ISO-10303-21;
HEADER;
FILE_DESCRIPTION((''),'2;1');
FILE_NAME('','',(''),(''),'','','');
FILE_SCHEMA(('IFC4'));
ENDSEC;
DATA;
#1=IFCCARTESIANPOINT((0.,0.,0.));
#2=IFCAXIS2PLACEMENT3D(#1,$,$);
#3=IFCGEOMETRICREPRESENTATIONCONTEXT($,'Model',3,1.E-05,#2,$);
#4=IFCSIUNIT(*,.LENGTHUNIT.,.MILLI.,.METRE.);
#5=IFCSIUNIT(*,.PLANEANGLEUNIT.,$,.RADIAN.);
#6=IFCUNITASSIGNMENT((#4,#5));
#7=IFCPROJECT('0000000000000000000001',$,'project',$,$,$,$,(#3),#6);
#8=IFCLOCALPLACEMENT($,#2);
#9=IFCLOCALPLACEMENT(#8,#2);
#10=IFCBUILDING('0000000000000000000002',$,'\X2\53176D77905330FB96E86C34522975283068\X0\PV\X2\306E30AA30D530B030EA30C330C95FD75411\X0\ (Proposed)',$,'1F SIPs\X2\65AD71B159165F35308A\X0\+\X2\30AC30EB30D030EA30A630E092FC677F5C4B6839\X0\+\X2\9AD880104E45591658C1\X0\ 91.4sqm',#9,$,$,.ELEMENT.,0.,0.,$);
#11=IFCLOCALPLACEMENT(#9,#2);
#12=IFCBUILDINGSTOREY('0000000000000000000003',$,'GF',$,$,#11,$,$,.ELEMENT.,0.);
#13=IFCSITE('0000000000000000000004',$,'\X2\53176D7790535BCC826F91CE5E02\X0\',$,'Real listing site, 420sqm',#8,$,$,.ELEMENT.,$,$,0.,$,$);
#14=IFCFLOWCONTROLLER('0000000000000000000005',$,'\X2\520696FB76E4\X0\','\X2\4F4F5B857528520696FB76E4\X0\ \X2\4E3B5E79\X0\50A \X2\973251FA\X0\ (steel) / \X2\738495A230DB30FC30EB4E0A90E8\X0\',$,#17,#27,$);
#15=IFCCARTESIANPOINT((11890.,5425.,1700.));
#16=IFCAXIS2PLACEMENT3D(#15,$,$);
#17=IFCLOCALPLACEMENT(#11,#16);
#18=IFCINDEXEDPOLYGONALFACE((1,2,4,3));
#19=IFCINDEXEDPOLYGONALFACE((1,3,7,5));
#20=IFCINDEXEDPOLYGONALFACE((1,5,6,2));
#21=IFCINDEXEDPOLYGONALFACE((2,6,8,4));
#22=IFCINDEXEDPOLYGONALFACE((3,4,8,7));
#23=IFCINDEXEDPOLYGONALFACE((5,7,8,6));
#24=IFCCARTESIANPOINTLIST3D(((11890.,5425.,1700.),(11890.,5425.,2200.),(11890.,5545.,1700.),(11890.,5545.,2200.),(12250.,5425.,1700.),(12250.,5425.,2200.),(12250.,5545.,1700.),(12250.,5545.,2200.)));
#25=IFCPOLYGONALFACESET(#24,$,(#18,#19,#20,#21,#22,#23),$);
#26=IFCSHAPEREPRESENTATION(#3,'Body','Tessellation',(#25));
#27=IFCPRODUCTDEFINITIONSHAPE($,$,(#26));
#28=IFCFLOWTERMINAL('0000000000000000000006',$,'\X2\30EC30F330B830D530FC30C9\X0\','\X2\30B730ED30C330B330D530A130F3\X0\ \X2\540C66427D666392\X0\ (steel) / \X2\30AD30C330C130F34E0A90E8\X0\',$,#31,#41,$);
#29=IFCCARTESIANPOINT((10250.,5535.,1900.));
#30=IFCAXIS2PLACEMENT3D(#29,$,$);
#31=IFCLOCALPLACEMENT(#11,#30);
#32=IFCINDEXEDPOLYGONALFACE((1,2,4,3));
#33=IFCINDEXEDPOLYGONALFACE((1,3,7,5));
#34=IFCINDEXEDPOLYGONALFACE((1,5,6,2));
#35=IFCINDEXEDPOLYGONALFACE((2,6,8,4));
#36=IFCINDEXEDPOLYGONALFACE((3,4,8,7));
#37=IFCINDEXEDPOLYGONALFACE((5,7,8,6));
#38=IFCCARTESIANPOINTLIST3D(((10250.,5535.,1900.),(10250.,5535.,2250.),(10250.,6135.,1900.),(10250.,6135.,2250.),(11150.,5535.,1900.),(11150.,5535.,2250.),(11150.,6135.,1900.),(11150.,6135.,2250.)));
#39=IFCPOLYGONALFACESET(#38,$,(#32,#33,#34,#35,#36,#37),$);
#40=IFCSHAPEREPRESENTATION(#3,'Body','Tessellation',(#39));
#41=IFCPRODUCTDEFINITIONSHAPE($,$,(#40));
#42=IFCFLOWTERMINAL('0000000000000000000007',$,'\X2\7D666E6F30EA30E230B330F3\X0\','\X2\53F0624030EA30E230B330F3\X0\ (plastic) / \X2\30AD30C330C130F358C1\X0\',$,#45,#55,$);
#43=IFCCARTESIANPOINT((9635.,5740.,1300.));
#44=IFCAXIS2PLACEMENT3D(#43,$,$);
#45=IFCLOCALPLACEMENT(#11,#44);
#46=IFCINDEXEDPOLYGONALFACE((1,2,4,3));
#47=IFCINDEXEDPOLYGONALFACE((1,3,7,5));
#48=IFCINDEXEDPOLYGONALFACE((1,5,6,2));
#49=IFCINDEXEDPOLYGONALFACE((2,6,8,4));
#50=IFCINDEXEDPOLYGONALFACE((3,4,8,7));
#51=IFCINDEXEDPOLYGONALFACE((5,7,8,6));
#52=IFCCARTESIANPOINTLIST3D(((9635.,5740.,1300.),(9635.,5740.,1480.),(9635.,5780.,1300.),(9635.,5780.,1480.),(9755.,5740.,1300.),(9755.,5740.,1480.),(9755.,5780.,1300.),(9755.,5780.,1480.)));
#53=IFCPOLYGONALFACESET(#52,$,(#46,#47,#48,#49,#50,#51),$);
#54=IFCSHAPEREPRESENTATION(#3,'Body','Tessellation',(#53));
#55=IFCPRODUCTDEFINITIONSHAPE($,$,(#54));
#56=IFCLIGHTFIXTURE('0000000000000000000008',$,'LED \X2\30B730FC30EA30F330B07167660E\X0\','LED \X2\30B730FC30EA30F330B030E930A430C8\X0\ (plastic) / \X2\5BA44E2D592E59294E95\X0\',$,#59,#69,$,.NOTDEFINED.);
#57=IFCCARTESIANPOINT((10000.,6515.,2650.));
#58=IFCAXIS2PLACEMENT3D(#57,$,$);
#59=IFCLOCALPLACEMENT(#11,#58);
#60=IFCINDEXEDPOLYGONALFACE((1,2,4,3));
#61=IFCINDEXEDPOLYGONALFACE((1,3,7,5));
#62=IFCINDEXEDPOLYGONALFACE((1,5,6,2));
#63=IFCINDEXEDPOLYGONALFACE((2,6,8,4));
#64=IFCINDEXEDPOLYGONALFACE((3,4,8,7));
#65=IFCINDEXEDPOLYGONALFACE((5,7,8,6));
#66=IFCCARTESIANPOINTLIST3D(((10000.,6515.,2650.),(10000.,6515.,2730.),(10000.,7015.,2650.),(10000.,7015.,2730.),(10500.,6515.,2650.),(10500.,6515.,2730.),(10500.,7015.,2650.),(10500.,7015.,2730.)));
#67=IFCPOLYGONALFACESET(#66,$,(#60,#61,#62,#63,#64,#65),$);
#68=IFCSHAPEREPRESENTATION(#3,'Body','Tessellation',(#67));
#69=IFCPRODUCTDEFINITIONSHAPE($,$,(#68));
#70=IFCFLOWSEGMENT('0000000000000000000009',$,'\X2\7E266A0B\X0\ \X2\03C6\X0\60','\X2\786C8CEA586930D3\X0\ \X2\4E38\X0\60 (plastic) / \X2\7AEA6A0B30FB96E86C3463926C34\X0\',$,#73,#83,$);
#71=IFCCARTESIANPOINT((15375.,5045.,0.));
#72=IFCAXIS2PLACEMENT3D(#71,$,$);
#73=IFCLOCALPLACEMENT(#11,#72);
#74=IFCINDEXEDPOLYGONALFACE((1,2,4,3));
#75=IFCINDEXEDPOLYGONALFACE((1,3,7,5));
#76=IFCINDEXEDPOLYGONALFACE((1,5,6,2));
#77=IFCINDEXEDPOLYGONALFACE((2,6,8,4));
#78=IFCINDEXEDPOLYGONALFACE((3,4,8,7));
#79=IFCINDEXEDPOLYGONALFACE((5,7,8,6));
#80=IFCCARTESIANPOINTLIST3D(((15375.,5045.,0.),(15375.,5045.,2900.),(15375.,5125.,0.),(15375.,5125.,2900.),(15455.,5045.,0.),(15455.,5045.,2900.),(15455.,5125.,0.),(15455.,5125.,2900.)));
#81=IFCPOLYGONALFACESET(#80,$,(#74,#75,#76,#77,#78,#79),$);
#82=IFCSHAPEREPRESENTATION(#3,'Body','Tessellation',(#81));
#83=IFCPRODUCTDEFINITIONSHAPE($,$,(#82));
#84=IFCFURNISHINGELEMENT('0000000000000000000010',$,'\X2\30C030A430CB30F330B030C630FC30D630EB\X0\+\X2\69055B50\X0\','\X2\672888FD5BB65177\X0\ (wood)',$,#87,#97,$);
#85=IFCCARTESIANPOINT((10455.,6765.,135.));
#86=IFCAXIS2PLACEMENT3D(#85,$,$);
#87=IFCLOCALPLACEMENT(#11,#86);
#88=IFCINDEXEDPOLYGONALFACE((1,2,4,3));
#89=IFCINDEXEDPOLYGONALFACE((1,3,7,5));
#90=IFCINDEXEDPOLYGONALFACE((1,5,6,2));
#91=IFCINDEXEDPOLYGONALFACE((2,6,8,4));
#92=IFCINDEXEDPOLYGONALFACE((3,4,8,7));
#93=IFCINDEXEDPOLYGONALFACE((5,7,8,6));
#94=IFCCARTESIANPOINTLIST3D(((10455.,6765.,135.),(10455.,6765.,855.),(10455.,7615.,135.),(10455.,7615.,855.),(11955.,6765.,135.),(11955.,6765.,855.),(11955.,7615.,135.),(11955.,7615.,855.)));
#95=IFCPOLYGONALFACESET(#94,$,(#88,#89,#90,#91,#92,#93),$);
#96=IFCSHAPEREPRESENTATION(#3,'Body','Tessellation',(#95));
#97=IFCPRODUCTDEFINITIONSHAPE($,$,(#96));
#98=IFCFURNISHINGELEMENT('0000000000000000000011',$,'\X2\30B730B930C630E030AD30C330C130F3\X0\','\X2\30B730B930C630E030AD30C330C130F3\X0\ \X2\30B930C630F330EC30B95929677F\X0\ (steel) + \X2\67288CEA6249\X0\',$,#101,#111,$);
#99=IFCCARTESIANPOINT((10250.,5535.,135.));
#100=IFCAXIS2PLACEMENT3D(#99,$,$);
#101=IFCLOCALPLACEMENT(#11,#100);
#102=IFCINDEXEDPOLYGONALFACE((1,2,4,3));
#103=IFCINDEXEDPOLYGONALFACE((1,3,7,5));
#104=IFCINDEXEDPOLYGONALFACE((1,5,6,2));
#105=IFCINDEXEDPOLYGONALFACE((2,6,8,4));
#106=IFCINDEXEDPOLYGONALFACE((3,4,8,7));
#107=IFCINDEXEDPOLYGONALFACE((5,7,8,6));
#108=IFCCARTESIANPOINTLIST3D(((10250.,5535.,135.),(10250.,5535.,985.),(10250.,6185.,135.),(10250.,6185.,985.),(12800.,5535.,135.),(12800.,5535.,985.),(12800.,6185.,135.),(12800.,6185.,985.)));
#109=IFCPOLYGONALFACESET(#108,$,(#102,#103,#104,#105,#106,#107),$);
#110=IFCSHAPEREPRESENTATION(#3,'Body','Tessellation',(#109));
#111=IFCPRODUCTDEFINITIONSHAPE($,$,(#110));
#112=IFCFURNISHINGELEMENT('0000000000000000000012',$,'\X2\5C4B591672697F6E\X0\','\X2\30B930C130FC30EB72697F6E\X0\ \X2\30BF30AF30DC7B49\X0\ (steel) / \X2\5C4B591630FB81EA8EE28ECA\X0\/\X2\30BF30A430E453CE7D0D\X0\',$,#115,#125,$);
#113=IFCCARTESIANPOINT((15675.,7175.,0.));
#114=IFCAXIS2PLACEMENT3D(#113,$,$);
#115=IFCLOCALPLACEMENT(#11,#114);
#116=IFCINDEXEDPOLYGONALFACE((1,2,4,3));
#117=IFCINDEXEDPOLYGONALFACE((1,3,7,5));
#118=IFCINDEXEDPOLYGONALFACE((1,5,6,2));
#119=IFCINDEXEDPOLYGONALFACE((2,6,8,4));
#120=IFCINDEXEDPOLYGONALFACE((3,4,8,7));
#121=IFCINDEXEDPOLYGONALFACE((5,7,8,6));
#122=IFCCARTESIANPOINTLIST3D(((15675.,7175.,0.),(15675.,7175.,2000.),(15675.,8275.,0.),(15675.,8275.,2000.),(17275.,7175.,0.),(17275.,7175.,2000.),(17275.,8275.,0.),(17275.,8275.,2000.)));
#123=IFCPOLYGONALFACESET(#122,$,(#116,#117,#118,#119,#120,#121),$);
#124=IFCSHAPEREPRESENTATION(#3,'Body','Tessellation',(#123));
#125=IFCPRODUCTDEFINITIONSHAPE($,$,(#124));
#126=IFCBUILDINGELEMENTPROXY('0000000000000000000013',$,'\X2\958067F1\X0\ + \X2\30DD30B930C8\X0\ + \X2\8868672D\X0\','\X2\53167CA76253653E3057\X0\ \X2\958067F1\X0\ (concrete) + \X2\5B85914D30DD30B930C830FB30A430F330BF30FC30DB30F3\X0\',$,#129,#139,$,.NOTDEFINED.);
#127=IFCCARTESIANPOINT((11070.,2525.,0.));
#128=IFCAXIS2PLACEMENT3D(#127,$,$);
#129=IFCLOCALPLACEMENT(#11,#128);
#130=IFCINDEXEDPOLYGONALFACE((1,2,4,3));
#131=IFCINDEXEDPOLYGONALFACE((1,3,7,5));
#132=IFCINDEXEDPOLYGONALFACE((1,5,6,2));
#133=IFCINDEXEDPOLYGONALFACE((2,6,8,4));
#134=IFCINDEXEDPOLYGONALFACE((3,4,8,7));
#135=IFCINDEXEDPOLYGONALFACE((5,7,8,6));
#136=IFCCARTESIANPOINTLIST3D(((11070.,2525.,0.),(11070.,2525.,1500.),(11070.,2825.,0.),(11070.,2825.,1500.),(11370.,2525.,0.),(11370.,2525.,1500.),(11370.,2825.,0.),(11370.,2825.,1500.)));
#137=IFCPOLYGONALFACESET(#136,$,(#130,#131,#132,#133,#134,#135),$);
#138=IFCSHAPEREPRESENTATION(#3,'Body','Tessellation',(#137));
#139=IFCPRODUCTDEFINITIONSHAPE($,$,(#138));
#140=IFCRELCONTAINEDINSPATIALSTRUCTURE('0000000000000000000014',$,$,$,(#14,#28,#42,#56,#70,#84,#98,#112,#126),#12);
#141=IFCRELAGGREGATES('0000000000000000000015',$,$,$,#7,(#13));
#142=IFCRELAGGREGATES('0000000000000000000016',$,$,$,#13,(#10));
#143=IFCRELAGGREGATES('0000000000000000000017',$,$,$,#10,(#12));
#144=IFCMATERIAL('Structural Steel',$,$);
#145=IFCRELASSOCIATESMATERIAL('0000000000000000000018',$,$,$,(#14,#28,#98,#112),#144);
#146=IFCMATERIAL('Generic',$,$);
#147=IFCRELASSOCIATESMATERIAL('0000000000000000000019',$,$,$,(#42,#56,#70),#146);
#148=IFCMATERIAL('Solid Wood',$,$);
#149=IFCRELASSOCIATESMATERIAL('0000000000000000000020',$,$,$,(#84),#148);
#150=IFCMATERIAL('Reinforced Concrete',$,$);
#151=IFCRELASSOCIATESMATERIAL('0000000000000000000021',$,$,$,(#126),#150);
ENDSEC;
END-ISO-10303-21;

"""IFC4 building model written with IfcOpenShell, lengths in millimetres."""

from ifc_helpers import new_model, si_unit, frame, frame_2d, origin, place, context, project, spatial, rectangle, extrude, material, element, save


model = new_model("IFC4")

# Units and contexts
model_context = context("Model", 3, precision=1e-05, world=origin())
ifc_project = project(units=[si_unit("LENGTHUNIT", "METRE", prefix="MILLI"), si_unit("PLANEANGLEUNIT", "RADIAN")], contexts=[model_context])

# Site, building, storey
site_placement = place(None, origin())
site = spatial("IfcSite", under=ifc_project, at=site_placement, Name="北海道富良野市", ObjectType="Real listing site, 420sqm", CompositionType="ELEMENT", RefElevation=0.0)
building_placement = place(site_placement, origin())
building = spatial("IfcBuilding", under=site, at=building_placement, Name="北海道・雨水利用とPVのオフグリッド志向 (Proposed)", ObjectType="1F SIPs断熱外張り+ガルバリウム鋼板屋根+高耐久外壁 91.4sqm", CompositionType="ELEMENT", ElevationOfRefHeight=0.0, ElevationOfTerrain=0.0)
storey_placement = place(building_placement, origin())
storey = spatial("IfcBuildingStorey", under=building, at=storey_placement, Name="GF", CompositionType="ELEMENT", Elevation=0.0)

# Shared definitions
ifc_material_1 = material(Name="Solid Wood")

# Shared definitions
ifc_material_2 = material(Name="Structural Steel")

# Shared definitions
ifc_material_3 = material(Name="Reinforced Concrete")

# Flow controller
flow_controller_placement = place(storey_placement, frame((11890.0, 5425.0, 1700.0)))
element("IfcFlowController", 1, at=flow_controller_placement, inside=storey, material=ifc_material_2, Name="分電盤", Description="住宅用分電盤 主幹50A 露出 (steel) / 玄関ホール上部", context=model_context, shape_type="SweptSolid", body=[
    extrude(rectangle(XDim=360.0, YDim=120.0, at=frame_2d((180.0, 60.0))), frame((11890.0, 5425.0, 1700.0)), (0.0, 0.0, 1.0), 500.0),
])

# Flow terminals
flow_terminal_1_placement = place(storey_placement, frame((10250.0, 5535.0, 1900.0)))
element("IfcFlowTerminal", 2, at=flow_terminal_1_placement, inside=storey, material=ifc_material_2, Name="レンジフード", Description="シロッコファン 同時給排 (steel) / キッチン上部", context=model_context, shape_type="SweptSolid", body=[
    extrude(rectangle(XDim=900.0, YDim=600.0, at=frame_2d((450.0, 300.0))), frame((10250.0, 5535.0, 1900.0)), (0.0, 0.0, 1.0), 350.0),
])
ifc_material_4 = material(Name="Generic")
flow_terminal_2_placement = place(storey_placement, frame((9635.0, 5740.0, 1300.0)))
element("IfcFlowTerminal", 3, at=flow_terminal_2_placement, inside=storey, material=ifc_material_4, Name="給湯リモコン", Description="台所リモコン (plastic) / キッチン壁", context=model_context, shape_type="SweptSolid", body=[
    extrude(rectangle(XDim=120.0, YDim=40.0, at=frame_2d((60.0, 20.0))), frame((9635.0, 5740.0, 1300.0)), (0.0, 0.0, 1.0), 180.0),
])

# Light fixture
light_fixture_placement = place(storey_placement, frame((10000.0, 6515.0, 2650.0)))
element("IfcLightFixture", 4, at=light_fixture_placement, inside=storey, material=ifc_material_4, Name="LED シーリング照明", Description="LED シーリングライト (plastic) / 室中央天井", PredefinedType="NOTDEFINED", context=model_context, shape_type="SweptSolid", body=[
    extrude(rectangle(XDim=500.0, YDim=500.0, at=frame_2d((250.0, 250.0))), frame((10000.0, 6515.0, 2650.0)), (0.0, 0.0, 1.0), 80.0),
])

# Flow segment
flow_segment_placement = place(storey_placement, frame((15375.0, 5045.0, 0.0)))
element("IfcFlowSegment", 5, at=flow_segment_placement, inside=storey, material=ifc_material_4, Name="縦樋 φ60", Description="硬質塩ビ 丸60 (plastic) / 竪樋・雨水排水", context=model_context, shape_type="SweptSolid", body=[
    extrude(rectangle(XDim=80.0, YDim=80.0, at=frame_2d((40.0, 40.0))), frame((15375.0, 5045.0, 0.0)), (0.0, 0.0, 1.0), 2900.0),
])

# Furnishing elements
furnishing_1_placement = place(storey_placement, frame((10455.0, 6765.0, 135.0)))
element("IfcFurnishingElement", 6, at=furnishing_1_placement, inside=storey, material=ifc_material_1, Name="ダイニングテーブル+椅子", Description="木製家具 (wood)", context=model_context, shape_type="SweptSolid", body=[
    extrude(rectangle(XDim=1500.0, YDim=850.0, at=frame_2d((750.0, 425.0))), frame((10455.0, 6765.0, 135.0)), (0.0, 0.0, 1.0), 720.0),
])
furnishing_2_placement = place(storey_placement, frame((10250.0, 5535.0, 135.0)))
element("IfcFurnishingElement", 7, at=furnishing_2_placement, inside=storey, material=ifc_material_2, Name="システムキッチン", Description="システムキッチン ステンレス天板 (steel) + 木質扉", context=model_context, shape_type="SweptSolid", body=[
    extrude(rectangle(XDim=2550.0, YDim=650.0, at=frame_2d((1275.0, 325.0))), frame((10250.0, 5535.0, 135.0)), (0.0, 0.0, 1.0), 850.0),
])
furnishing_3_placement = place(storey_placement, frame((15675.0, 7175.0, 0.0)))
element("IfcFurnishingElement", 8, at=furnishing_3_placement, inside=storey, material=ifc_material_2, Name="屋外物置", Description="スチール物置 タクボ等 (steel) / 屋外・自転車/タイヤ収納", context=model_context, shape_type="SweptSolid", body=[
    extrude(rectangle(XDim=1600.0, YDim=1100.0, at=frame_2d((800.0, 550.0))), frame((15675.0, 7175.0, 0.0)), (0.0, 0.0, 1.0), 2000.0),
])

# Building element proxy
proxy_placement = place(storey_placement, frame((11070.0, 2525.0, 0.0)))
element("IfcBuildingElementProxy", 9, at=proxy_placement, inside=storey, material=ifc_material_3, Name="門柱 + ポスト + 表札", Description="化粧打放し 門柱 (concrete) + 宅配ポスト・インターホン", PredefinedType="NOTDEFINED", context=model_context, shape_type="SweptSolid", body=[
    extrude(rectangle(XDim=300.0, YDim=300.0, at=frame_2d((150.0, 150.0))), frame((11070.0, 2525.0, 0.0)), (0.0, 0.0, 1.0), 1500.0),
])

save(model, "model.ifc")
